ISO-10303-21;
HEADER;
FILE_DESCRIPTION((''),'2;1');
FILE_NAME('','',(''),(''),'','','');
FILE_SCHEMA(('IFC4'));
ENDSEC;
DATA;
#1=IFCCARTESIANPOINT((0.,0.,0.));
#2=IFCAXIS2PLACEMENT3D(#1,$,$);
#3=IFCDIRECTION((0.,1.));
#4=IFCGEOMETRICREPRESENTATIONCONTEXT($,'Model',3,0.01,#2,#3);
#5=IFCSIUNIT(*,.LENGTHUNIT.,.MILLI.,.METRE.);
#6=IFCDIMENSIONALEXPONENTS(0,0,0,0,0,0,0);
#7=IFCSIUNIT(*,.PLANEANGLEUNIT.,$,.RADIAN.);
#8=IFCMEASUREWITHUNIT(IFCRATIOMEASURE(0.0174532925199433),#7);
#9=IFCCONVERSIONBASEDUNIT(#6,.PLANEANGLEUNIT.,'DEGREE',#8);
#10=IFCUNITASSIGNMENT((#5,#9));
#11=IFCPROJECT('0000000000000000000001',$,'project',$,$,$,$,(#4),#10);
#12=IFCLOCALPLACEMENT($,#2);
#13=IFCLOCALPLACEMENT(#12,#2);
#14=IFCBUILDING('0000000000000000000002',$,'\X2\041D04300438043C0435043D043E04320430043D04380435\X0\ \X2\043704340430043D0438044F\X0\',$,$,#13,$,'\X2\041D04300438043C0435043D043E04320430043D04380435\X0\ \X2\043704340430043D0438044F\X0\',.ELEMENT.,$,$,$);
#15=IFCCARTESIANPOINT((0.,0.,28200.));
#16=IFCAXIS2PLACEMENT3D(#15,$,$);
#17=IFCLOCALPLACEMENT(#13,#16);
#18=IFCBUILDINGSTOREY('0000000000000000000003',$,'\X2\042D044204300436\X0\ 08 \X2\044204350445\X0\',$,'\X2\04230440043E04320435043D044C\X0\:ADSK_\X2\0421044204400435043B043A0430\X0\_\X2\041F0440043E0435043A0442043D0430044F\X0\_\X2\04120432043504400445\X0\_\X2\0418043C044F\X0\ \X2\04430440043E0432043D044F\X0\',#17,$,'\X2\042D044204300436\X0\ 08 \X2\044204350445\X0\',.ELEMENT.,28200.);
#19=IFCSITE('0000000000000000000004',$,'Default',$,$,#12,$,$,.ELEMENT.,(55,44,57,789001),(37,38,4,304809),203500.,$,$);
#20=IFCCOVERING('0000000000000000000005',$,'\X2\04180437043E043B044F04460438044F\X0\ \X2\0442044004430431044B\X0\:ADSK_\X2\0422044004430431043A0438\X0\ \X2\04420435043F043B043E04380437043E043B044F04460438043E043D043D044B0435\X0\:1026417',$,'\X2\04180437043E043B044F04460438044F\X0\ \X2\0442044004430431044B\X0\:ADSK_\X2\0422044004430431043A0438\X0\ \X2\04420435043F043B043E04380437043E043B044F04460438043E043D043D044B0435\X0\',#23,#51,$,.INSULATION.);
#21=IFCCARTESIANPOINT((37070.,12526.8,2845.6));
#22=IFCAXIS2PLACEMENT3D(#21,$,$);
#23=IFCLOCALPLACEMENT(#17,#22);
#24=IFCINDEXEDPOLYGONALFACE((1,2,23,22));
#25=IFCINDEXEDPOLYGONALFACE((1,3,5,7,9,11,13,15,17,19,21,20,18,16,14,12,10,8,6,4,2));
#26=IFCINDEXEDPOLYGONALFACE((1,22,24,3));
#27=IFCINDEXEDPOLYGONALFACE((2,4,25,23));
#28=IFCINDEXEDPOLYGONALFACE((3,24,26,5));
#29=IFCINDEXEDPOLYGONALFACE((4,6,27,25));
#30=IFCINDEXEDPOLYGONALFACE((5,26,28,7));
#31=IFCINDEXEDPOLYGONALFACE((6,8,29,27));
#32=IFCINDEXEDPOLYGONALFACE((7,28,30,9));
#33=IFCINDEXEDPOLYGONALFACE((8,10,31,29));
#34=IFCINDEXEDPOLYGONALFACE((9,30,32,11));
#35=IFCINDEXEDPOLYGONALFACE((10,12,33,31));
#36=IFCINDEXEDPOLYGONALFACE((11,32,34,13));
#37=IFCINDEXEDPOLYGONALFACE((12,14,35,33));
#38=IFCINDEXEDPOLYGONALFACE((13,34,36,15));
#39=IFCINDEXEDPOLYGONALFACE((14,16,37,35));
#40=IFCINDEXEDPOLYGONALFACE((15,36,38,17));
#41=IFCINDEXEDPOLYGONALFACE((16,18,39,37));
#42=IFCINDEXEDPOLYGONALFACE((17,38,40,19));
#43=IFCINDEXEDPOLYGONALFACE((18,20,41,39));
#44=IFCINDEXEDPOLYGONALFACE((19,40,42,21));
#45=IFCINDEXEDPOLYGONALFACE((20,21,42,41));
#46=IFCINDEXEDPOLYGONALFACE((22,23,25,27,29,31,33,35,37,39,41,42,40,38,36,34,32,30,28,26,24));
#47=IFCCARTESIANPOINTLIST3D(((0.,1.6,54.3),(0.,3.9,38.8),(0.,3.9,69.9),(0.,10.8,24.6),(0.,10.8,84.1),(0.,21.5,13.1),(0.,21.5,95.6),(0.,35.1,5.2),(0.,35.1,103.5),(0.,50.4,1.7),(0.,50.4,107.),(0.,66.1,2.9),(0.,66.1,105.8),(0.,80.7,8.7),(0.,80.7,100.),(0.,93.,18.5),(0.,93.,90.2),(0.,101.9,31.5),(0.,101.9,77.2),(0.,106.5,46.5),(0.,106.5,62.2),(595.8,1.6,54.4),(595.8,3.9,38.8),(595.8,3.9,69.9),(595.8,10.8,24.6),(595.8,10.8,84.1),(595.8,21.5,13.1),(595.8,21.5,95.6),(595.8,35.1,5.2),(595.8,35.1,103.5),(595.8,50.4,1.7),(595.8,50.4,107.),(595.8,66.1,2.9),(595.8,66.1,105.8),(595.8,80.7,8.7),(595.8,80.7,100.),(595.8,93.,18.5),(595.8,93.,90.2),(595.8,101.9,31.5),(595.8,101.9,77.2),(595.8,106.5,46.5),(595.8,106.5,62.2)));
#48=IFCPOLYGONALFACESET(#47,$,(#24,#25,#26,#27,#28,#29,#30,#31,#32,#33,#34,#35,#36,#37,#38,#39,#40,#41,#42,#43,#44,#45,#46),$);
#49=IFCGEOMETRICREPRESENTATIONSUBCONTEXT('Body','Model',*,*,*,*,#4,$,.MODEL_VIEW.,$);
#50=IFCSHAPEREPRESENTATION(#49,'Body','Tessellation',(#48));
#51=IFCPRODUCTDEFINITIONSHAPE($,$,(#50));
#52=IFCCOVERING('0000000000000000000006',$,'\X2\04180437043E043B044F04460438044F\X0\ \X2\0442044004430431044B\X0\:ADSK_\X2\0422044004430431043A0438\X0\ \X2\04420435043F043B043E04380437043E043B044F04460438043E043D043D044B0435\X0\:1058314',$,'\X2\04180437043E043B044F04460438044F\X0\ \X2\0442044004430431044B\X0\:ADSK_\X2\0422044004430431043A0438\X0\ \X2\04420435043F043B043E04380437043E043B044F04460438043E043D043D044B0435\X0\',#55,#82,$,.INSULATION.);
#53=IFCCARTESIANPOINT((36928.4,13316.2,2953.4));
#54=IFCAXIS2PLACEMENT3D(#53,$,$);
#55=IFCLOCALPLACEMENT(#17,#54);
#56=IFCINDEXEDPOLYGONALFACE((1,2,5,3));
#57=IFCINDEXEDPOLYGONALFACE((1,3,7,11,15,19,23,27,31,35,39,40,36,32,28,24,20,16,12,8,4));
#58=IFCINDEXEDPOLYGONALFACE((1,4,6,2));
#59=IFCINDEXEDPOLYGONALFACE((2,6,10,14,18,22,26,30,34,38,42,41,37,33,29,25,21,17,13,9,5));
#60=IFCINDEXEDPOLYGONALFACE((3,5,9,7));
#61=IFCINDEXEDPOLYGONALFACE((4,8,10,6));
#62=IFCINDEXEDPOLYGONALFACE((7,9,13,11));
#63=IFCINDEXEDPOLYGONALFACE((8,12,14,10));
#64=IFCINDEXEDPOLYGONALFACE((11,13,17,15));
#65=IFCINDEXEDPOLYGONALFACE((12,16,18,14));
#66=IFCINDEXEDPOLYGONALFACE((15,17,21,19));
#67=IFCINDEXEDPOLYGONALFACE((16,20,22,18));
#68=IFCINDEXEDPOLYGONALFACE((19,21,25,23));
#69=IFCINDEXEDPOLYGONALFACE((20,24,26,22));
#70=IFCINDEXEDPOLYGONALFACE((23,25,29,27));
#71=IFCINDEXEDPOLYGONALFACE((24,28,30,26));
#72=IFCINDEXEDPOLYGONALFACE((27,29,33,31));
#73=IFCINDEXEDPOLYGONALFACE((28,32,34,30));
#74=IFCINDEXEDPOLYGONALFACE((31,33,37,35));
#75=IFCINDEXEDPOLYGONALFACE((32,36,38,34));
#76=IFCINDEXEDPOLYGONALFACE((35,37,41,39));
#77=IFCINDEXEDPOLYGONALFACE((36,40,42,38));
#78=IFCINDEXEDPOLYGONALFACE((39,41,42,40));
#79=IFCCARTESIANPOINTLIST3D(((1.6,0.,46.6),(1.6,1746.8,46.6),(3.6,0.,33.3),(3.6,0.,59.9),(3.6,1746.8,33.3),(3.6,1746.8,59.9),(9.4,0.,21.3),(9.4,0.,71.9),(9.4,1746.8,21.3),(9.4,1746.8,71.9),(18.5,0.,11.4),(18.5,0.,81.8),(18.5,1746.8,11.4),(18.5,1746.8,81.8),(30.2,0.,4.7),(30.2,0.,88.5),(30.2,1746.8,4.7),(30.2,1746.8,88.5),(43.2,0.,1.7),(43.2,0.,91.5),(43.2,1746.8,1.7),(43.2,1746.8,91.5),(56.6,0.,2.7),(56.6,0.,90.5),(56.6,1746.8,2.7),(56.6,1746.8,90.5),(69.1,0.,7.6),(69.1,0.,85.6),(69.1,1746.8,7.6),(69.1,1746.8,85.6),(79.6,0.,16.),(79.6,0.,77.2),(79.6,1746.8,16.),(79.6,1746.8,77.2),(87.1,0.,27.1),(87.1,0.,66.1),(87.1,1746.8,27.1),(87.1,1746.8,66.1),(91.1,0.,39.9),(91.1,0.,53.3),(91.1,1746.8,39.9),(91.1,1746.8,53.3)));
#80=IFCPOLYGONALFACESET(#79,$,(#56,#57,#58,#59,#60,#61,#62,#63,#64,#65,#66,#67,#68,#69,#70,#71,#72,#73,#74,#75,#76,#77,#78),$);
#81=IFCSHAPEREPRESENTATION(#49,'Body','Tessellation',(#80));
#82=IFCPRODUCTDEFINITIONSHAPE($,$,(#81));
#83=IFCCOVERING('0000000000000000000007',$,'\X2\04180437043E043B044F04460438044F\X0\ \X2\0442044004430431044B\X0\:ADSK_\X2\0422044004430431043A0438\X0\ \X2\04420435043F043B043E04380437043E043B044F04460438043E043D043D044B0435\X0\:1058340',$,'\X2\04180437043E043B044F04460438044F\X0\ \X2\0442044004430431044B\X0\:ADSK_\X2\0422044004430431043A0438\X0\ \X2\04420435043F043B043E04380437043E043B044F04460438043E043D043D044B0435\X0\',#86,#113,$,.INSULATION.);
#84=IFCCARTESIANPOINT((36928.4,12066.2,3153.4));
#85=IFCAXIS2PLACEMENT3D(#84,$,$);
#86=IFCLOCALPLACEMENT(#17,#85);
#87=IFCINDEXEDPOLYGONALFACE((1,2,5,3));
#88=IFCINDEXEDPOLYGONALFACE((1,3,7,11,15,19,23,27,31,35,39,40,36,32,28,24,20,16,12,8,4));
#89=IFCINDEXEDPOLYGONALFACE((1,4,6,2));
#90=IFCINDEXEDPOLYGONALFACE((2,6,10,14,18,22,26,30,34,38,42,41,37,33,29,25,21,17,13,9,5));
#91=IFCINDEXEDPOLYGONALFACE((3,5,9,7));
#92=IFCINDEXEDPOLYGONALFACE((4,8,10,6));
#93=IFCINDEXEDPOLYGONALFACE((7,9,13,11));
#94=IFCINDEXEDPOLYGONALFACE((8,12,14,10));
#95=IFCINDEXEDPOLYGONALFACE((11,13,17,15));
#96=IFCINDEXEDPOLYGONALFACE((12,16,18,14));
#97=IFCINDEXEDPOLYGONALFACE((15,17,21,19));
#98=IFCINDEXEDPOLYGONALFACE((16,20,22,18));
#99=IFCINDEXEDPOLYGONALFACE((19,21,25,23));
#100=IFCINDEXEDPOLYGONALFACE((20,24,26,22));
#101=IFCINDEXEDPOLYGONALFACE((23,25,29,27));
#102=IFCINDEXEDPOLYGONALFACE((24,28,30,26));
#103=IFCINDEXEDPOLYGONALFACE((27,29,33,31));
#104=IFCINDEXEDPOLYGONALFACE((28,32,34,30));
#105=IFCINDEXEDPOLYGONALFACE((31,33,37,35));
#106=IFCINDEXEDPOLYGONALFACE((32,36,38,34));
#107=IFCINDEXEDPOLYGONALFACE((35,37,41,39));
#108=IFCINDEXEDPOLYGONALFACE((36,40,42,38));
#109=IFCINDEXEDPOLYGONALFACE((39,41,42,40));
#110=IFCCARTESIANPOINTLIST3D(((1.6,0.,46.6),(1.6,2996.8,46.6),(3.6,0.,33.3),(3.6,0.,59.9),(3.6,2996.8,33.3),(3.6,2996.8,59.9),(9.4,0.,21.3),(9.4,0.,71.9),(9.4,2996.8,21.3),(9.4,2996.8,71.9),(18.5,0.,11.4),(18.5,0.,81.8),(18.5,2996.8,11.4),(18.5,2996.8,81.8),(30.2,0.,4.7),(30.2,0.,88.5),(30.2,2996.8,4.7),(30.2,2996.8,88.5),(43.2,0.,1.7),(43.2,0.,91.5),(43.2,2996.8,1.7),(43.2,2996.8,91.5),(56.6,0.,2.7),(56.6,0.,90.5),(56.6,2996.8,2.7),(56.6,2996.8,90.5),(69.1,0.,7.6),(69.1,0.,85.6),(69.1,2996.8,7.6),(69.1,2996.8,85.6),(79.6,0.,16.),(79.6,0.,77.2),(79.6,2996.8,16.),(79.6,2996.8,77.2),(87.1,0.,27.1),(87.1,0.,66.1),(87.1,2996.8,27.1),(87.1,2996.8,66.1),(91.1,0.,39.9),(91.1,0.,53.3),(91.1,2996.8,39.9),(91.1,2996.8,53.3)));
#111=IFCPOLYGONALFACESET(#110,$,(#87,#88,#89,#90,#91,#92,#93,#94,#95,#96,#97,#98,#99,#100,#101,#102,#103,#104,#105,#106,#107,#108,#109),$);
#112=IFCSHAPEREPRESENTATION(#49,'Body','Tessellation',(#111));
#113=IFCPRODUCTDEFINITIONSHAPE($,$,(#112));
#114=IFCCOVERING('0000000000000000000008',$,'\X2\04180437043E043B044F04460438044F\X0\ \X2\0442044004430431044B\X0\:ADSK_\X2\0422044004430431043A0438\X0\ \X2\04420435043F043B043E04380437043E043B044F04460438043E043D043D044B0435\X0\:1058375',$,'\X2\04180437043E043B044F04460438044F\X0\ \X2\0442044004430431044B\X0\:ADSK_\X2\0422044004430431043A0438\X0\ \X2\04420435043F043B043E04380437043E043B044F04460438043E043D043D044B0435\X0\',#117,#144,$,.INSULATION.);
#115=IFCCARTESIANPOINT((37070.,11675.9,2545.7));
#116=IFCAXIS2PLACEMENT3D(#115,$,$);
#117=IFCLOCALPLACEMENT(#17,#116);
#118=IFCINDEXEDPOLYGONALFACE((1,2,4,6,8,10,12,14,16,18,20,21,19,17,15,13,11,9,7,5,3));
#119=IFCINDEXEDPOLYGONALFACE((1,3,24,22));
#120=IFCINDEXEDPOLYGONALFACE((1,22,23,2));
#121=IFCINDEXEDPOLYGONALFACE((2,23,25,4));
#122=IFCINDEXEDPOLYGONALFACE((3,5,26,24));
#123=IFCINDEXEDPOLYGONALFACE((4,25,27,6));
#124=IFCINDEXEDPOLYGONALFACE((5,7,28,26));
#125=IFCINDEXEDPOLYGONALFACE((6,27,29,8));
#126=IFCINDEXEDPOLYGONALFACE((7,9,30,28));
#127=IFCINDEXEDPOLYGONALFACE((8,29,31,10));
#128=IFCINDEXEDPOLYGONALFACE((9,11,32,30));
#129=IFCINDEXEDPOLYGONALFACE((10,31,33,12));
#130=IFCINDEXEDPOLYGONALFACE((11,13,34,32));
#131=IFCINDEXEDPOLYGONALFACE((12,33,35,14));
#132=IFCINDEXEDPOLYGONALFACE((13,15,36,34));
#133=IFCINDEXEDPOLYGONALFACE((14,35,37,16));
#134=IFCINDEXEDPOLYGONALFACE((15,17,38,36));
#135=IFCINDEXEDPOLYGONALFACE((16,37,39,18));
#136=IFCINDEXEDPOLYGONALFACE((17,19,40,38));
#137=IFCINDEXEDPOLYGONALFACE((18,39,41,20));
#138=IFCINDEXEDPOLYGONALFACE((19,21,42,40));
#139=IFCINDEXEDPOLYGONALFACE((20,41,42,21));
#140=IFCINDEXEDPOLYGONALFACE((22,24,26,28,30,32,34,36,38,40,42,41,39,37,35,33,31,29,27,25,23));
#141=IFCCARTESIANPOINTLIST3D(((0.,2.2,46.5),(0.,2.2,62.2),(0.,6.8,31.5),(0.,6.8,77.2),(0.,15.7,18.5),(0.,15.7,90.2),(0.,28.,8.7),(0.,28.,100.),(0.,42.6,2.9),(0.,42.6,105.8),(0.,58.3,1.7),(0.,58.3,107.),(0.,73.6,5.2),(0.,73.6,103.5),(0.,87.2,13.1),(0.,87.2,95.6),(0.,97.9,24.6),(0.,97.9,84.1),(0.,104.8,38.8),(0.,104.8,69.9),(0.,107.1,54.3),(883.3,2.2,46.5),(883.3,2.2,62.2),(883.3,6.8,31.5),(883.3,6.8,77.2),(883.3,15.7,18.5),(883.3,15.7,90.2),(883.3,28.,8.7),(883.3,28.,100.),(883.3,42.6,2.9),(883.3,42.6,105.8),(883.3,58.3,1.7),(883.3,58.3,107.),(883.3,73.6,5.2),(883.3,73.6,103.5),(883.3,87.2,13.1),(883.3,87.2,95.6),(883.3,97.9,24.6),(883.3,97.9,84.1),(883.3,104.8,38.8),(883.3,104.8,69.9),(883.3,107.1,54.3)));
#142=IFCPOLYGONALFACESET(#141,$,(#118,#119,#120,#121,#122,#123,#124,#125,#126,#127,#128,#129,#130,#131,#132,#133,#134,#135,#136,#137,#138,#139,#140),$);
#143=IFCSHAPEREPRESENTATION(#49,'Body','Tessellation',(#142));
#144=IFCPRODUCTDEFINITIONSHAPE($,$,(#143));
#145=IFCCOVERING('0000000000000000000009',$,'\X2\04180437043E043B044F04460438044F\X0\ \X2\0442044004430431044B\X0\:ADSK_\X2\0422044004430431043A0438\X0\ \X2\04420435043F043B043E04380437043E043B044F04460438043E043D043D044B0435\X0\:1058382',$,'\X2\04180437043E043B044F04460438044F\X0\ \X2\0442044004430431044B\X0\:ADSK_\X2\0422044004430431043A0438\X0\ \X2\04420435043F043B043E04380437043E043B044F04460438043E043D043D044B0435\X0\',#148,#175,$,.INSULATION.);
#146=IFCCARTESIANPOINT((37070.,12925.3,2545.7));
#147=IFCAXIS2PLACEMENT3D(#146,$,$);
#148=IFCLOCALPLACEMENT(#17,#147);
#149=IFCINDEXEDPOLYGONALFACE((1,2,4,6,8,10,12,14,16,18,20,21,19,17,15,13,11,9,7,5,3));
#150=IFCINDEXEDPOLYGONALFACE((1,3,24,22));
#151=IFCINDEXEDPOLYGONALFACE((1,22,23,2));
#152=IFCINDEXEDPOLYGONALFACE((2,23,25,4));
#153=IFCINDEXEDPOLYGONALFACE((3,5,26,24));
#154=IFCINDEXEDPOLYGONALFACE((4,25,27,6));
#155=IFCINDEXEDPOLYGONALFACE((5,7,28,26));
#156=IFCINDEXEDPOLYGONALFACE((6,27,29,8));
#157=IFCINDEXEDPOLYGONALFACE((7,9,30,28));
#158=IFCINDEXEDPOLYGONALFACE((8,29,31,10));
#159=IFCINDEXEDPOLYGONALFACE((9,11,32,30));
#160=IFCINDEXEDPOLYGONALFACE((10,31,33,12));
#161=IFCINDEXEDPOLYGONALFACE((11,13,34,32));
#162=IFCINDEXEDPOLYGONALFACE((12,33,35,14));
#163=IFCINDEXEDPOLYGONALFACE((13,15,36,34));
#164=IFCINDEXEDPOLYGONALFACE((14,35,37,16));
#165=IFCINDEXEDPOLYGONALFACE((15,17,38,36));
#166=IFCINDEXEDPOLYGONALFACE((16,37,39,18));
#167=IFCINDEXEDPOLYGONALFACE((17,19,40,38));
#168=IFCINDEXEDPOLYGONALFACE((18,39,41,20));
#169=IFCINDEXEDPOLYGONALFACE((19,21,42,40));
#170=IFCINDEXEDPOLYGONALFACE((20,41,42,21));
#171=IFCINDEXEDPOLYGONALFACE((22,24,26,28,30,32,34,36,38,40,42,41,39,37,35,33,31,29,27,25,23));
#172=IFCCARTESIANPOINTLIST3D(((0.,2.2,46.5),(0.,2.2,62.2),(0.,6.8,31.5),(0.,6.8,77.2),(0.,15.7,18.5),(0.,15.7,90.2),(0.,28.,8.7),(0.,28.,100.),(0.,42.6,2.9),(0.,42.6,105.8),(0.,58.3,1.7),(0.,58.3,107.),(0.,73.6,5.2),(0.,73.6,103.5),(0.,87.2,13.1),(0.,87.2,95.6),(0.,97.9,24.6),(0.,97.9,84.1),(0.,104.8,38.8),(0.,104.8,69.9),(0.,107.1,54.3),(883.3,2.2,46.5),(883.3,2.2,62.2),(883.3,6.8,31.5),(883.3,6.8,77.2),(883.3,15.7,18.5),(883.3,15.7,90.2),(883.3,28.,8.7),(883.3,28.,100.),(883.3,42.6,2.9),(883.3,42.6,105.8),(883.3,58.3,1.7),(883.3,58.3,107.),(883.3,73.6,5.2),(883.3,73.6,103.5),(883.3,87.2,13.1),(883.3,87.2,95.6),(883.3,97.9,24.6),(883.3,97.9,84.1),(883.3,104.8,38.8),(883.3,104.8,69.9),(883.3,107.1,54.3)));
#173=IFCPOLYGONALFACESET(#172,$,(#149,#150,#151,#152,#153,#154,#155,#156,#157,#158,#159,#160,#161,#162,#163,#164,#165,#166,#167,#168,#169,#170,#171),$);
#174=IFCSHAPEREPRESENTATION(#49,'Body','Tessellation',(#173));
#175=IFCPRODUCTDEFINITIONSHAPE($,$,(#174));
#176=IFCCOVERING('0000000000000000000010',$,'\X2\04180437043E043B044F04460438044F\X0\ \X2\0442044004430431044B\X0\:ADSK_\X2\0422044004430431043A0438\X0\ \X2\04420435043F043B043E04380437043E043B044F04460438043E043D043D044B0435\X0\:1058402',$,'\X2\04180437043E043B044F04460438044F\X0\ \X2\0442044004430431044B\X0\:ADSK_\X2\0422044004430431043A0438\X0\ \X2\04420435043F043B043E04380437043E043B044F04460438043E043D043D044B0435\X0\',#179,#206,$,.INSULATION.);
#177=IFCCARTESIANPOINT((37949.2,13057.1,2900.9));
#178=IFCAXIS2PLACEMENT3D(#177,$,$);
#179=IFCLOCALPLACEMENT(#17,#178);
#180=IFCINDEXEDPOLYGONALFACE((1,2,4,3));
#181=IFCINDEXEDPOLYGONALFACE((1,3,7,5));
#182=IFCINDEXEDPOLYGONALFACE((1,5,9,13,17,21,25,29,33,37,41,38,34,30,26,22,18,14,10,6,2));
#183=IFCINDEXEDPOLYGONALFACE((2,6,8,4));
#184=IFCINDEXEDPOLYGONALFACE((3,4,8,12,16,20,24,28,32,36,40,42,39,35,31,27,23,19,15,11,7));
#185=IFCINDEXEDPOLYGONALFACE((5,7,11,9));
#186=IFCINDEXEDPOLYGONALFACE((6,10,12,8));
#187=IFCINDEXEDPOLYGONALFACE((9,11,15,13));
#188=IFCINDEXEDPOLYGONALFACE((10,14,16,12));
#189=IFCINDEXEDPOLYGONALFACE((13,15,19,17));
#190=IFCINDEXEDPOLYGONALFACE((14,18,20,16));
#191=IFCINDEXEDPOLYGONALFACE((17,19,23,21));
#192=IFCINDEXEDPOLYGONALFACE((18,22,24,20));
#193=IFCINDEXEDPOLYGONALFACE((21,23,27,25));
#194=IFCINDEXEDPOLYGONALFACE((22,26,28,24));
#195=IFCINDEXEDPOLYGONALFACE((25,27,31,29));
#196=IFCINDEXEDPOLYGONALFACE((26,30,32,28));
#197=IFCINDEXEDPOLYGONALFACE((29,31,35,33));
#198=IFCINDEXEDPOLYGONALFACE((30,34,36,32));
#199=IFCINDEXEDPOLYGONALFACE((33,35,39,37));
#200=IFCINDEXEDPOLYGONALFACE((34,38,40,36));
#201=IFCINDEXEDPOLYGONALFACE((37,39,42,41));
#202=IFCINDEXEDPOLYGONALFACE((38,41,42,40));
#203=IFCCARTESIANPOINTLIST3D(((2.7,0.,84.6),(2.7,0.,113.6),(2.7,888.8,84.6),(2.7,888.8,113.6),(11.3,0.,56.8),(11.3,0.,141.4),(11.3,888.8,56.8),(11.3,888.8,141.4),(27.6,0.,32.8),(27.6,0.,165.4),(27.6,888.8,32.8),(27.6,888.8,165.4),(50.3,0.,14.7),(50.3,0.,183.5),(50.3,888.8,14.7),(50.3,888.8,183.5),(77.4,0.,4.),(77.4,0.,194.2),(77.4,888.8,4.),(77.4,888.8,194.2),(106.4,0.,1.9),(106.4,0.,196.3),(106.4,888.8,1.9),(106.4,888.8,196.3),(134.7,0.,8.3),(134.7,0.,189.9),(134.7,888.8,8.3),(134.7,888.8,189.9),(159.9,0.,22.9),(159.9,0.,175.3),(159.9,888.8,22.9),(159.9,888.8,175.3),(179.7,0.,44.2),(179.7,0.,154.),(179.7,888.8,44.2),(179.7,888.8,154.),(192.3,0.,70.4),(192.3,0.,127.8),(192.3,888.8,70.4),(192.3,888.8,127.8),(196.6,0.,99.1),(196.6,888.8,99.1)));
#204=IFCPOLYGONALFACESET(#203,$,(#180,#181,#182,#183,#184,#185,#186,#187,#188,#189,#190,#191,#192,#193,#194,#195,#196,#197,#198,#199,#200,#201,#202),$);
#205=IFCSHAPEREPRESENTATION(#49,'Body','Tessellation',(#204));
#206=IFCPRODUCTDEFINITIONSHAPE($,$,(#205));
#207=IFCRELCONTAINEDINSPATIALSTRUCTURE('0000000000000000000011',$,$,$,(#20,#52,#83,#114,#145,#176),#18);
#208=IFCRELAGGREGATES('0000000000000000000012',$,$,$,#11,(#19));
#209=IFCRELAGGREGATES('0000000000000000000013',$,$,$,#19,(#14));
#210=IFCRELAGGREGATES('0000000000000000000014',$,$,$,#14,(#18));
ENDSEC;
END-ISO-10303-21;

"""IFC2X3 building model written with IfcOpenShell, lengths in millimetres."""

from ifc_helpers import new_model, entity, si_unit, converted_unit, direction, frame, origin, origin_2d_with_axis, place, context, subcontext, project, spatial, circle, extrude, element, save


model = new_model("IFC2X3")

# Units and contexts
model_context = context("Model", 3, precision=0.01, world=origin(), true_north=direction((0.0, 1.0)))
body_context = subcontext(model_context, "Body", "Model", "MODEL_VIEW")
ifc_project = project(units=[si_unit("LENGTHUNIT", "METRE", prefix="MILLI"), converted_unit("PLANEANGLEUNIT", "DEGREE", entity("IfcRatioMeasure", 0.0174532925199433), si_unit("PLANEANGLEUNIT", "RADIAN"), dimensions=[0, 0, 0, 0, 0, 0, 0])], contexts=[model_context])

# Site, building, storey
site_placement = place(None, origin())
site = spatial("IfcSite", under=ifc_project, at=site_placement, Name="Default", CompositionType="ELEMENT", RefLatitude=(55, 44, 57, 789001), RefLongitude=(37, 38, 4, 304809), RefElevation=203500.0)
building_placement = place(site_placement, origin())
building = spatial("IfcBuilding", under=site, at=building_placement, Name="Наименование здания", LongName="Наименование здания", CompositionType="ELEMENT")
storey_placement = place(building_placement, frame((0.0, 0.0, 28200.0)))
storey = spatial("IfcBuildingStorey", under=building, at=storey_placement, Name="Этаж 08 тех", ObjectType="Уровень:ADSK_Стрелка_Проектная_Вверх_Имя уровня", LongName="Этаж 08 тех", CompositionType="ELEMENT", Elevation=28200.0)

# Coverings
covering_1_placement = place(storey_placement, frame((37070.0, 12526.8, 2845.6)))
element("IfcCovering", 1, at=covering_1_placement, inside=storey, Name="Изоляция трубы:ADSK_Трубки теплоизоляционные:1026417", ObjectType="Изоляция трубы:ADSK_Трубки теплоизоляционные", PredefinedType="INSULATION", context=body_context, shape_type="SweptSolid", body=[
    extrude(circle(Radius=52.8, at=origin_2d_with_axis()), frame((0.0, 54.4, 54.4), z_axis=(1.0, 0.0, 0.000002), x_axis=(0.0, -1.0, 0.0)), (0.0, 0.0, 1.0), 595.8),
])
covering_2_placement = place(storey_placement, frame((36928.4, 13316.2, 2953.4)))
element("IfcCovering", 2, at=covering_2_placement, inside=storey, Name="Изоляция трубы:ADSK_Трубки теплоизоляционные:1058314", ObjectType="Изоляция трубы:ADSK_Трубки теплоизоляционные", PredefinedType="INSULATION", context=body_context, shape_type="SweptSolid", body=[
    extrude(circle(Radius=45.0, at=origin_2d_with_axis()), frame((46.6, 0.0, 46.6), z_axis=(0.0, 1.0, 0.0), x_axis=(-1.0, 0.0, 0.0)), (0.0, 0.0, 1.0), 1746.8),
])
covering_3_placement = place(storey_placement, frame((36928.4, 12066.2, 3153.4)))
element("IfcCovering", 3, at=covering_3_placement, inside=storey, Name="Изоляция трубы:ADSK_Трубки теплоизоляционные:1058340", ObjectType="Изоляция трубы:ADSK_Трубки теплоизоляционные", PredefinedType="INSULATION", context=body_context, shape_type="SweptSolid", body=[
    extrude(circle(Radius=45.0, at=origin_2d_with_axis()), frame((46.6, 0.0, 46.6), z_axis=(0.0, 1.0, 0.0), x_axis=(-1.0, 0.0, 0.0)), (0.0, 0.0, 1.0), 2996.8),
])
covering_4_placement = place(storey_placement, frame((37070.0, 11675.9, 2545.7)))
element("IfcCovering", 4, at=covering_4_placement, inside=storey, Name="Изоляция трубы:ADSK_Трубки теплоизоляционные:1058375", ObjectType="Изоляция трубы:ADSK_Трубки теплоизоляционные", PredefinedType="INSULATION", context=body_context, shape_type="SweptSolid", body=[
    extrude(circle(Radius=52.8, at=origin_2d_with_axis()), frame((0.0, 54.4, 54.4), z_axis=(1.0, 0.0, 0.0), x_axis=(0.0, 1.0, 0.0)), (0.0, 0.0, 1.0), 883.3),
])
covering_5_placement = place(storey_placement, frame((37070.0, 12925.3, 2545.7)))
element("IfcCovering", 5, at=covering_5_placement, inside=storey, Name="Изоляция трубы:ADSK_Трубки теплоизоляционные:1058382", ObjectType="Изоляция трубы:ADSK_Трубки теплоизоляционные", PredefinedType="INSULATION", context=body_context, shape_type="SweptSolid", body=[
    extrude(circle(Radius=52.8, at=origin_2d_with_axis()), frame((0.0, 54.4, 54.4), z_axis=(1.0, 0.0, 0.0), x_axis=(0.0, 1.0, 0.0)), (0.0, 0.0, 1.0), 883.3),
])
covering_6_placement = place(storey_placement, frame((37949.2, 13057.1, 2900.9)))
element("IfcCovering", 6, at=covering_6_placement, inside=storey, Name="Изоляция трубы:ADSK_Трубки теплоизоляционные:1058402", ObjectType="Изоляция трубы:ADSK_Трубки теплоизоляционные", PredefinedType="INSULATION", context=body_context, shape_type="SweptSolid", body=[
    extrude(circle(Radius=97.5, at=origin_2d_with_axis()), frame((99.1, 0.0, 99.1), z_axis=(0.0, 1.0, 0.0), x_axis=(1.0, 0.0, 0.0)), (0.0, 0.0, 1.0), 888.8),
])

save(model, "model.ifc")
